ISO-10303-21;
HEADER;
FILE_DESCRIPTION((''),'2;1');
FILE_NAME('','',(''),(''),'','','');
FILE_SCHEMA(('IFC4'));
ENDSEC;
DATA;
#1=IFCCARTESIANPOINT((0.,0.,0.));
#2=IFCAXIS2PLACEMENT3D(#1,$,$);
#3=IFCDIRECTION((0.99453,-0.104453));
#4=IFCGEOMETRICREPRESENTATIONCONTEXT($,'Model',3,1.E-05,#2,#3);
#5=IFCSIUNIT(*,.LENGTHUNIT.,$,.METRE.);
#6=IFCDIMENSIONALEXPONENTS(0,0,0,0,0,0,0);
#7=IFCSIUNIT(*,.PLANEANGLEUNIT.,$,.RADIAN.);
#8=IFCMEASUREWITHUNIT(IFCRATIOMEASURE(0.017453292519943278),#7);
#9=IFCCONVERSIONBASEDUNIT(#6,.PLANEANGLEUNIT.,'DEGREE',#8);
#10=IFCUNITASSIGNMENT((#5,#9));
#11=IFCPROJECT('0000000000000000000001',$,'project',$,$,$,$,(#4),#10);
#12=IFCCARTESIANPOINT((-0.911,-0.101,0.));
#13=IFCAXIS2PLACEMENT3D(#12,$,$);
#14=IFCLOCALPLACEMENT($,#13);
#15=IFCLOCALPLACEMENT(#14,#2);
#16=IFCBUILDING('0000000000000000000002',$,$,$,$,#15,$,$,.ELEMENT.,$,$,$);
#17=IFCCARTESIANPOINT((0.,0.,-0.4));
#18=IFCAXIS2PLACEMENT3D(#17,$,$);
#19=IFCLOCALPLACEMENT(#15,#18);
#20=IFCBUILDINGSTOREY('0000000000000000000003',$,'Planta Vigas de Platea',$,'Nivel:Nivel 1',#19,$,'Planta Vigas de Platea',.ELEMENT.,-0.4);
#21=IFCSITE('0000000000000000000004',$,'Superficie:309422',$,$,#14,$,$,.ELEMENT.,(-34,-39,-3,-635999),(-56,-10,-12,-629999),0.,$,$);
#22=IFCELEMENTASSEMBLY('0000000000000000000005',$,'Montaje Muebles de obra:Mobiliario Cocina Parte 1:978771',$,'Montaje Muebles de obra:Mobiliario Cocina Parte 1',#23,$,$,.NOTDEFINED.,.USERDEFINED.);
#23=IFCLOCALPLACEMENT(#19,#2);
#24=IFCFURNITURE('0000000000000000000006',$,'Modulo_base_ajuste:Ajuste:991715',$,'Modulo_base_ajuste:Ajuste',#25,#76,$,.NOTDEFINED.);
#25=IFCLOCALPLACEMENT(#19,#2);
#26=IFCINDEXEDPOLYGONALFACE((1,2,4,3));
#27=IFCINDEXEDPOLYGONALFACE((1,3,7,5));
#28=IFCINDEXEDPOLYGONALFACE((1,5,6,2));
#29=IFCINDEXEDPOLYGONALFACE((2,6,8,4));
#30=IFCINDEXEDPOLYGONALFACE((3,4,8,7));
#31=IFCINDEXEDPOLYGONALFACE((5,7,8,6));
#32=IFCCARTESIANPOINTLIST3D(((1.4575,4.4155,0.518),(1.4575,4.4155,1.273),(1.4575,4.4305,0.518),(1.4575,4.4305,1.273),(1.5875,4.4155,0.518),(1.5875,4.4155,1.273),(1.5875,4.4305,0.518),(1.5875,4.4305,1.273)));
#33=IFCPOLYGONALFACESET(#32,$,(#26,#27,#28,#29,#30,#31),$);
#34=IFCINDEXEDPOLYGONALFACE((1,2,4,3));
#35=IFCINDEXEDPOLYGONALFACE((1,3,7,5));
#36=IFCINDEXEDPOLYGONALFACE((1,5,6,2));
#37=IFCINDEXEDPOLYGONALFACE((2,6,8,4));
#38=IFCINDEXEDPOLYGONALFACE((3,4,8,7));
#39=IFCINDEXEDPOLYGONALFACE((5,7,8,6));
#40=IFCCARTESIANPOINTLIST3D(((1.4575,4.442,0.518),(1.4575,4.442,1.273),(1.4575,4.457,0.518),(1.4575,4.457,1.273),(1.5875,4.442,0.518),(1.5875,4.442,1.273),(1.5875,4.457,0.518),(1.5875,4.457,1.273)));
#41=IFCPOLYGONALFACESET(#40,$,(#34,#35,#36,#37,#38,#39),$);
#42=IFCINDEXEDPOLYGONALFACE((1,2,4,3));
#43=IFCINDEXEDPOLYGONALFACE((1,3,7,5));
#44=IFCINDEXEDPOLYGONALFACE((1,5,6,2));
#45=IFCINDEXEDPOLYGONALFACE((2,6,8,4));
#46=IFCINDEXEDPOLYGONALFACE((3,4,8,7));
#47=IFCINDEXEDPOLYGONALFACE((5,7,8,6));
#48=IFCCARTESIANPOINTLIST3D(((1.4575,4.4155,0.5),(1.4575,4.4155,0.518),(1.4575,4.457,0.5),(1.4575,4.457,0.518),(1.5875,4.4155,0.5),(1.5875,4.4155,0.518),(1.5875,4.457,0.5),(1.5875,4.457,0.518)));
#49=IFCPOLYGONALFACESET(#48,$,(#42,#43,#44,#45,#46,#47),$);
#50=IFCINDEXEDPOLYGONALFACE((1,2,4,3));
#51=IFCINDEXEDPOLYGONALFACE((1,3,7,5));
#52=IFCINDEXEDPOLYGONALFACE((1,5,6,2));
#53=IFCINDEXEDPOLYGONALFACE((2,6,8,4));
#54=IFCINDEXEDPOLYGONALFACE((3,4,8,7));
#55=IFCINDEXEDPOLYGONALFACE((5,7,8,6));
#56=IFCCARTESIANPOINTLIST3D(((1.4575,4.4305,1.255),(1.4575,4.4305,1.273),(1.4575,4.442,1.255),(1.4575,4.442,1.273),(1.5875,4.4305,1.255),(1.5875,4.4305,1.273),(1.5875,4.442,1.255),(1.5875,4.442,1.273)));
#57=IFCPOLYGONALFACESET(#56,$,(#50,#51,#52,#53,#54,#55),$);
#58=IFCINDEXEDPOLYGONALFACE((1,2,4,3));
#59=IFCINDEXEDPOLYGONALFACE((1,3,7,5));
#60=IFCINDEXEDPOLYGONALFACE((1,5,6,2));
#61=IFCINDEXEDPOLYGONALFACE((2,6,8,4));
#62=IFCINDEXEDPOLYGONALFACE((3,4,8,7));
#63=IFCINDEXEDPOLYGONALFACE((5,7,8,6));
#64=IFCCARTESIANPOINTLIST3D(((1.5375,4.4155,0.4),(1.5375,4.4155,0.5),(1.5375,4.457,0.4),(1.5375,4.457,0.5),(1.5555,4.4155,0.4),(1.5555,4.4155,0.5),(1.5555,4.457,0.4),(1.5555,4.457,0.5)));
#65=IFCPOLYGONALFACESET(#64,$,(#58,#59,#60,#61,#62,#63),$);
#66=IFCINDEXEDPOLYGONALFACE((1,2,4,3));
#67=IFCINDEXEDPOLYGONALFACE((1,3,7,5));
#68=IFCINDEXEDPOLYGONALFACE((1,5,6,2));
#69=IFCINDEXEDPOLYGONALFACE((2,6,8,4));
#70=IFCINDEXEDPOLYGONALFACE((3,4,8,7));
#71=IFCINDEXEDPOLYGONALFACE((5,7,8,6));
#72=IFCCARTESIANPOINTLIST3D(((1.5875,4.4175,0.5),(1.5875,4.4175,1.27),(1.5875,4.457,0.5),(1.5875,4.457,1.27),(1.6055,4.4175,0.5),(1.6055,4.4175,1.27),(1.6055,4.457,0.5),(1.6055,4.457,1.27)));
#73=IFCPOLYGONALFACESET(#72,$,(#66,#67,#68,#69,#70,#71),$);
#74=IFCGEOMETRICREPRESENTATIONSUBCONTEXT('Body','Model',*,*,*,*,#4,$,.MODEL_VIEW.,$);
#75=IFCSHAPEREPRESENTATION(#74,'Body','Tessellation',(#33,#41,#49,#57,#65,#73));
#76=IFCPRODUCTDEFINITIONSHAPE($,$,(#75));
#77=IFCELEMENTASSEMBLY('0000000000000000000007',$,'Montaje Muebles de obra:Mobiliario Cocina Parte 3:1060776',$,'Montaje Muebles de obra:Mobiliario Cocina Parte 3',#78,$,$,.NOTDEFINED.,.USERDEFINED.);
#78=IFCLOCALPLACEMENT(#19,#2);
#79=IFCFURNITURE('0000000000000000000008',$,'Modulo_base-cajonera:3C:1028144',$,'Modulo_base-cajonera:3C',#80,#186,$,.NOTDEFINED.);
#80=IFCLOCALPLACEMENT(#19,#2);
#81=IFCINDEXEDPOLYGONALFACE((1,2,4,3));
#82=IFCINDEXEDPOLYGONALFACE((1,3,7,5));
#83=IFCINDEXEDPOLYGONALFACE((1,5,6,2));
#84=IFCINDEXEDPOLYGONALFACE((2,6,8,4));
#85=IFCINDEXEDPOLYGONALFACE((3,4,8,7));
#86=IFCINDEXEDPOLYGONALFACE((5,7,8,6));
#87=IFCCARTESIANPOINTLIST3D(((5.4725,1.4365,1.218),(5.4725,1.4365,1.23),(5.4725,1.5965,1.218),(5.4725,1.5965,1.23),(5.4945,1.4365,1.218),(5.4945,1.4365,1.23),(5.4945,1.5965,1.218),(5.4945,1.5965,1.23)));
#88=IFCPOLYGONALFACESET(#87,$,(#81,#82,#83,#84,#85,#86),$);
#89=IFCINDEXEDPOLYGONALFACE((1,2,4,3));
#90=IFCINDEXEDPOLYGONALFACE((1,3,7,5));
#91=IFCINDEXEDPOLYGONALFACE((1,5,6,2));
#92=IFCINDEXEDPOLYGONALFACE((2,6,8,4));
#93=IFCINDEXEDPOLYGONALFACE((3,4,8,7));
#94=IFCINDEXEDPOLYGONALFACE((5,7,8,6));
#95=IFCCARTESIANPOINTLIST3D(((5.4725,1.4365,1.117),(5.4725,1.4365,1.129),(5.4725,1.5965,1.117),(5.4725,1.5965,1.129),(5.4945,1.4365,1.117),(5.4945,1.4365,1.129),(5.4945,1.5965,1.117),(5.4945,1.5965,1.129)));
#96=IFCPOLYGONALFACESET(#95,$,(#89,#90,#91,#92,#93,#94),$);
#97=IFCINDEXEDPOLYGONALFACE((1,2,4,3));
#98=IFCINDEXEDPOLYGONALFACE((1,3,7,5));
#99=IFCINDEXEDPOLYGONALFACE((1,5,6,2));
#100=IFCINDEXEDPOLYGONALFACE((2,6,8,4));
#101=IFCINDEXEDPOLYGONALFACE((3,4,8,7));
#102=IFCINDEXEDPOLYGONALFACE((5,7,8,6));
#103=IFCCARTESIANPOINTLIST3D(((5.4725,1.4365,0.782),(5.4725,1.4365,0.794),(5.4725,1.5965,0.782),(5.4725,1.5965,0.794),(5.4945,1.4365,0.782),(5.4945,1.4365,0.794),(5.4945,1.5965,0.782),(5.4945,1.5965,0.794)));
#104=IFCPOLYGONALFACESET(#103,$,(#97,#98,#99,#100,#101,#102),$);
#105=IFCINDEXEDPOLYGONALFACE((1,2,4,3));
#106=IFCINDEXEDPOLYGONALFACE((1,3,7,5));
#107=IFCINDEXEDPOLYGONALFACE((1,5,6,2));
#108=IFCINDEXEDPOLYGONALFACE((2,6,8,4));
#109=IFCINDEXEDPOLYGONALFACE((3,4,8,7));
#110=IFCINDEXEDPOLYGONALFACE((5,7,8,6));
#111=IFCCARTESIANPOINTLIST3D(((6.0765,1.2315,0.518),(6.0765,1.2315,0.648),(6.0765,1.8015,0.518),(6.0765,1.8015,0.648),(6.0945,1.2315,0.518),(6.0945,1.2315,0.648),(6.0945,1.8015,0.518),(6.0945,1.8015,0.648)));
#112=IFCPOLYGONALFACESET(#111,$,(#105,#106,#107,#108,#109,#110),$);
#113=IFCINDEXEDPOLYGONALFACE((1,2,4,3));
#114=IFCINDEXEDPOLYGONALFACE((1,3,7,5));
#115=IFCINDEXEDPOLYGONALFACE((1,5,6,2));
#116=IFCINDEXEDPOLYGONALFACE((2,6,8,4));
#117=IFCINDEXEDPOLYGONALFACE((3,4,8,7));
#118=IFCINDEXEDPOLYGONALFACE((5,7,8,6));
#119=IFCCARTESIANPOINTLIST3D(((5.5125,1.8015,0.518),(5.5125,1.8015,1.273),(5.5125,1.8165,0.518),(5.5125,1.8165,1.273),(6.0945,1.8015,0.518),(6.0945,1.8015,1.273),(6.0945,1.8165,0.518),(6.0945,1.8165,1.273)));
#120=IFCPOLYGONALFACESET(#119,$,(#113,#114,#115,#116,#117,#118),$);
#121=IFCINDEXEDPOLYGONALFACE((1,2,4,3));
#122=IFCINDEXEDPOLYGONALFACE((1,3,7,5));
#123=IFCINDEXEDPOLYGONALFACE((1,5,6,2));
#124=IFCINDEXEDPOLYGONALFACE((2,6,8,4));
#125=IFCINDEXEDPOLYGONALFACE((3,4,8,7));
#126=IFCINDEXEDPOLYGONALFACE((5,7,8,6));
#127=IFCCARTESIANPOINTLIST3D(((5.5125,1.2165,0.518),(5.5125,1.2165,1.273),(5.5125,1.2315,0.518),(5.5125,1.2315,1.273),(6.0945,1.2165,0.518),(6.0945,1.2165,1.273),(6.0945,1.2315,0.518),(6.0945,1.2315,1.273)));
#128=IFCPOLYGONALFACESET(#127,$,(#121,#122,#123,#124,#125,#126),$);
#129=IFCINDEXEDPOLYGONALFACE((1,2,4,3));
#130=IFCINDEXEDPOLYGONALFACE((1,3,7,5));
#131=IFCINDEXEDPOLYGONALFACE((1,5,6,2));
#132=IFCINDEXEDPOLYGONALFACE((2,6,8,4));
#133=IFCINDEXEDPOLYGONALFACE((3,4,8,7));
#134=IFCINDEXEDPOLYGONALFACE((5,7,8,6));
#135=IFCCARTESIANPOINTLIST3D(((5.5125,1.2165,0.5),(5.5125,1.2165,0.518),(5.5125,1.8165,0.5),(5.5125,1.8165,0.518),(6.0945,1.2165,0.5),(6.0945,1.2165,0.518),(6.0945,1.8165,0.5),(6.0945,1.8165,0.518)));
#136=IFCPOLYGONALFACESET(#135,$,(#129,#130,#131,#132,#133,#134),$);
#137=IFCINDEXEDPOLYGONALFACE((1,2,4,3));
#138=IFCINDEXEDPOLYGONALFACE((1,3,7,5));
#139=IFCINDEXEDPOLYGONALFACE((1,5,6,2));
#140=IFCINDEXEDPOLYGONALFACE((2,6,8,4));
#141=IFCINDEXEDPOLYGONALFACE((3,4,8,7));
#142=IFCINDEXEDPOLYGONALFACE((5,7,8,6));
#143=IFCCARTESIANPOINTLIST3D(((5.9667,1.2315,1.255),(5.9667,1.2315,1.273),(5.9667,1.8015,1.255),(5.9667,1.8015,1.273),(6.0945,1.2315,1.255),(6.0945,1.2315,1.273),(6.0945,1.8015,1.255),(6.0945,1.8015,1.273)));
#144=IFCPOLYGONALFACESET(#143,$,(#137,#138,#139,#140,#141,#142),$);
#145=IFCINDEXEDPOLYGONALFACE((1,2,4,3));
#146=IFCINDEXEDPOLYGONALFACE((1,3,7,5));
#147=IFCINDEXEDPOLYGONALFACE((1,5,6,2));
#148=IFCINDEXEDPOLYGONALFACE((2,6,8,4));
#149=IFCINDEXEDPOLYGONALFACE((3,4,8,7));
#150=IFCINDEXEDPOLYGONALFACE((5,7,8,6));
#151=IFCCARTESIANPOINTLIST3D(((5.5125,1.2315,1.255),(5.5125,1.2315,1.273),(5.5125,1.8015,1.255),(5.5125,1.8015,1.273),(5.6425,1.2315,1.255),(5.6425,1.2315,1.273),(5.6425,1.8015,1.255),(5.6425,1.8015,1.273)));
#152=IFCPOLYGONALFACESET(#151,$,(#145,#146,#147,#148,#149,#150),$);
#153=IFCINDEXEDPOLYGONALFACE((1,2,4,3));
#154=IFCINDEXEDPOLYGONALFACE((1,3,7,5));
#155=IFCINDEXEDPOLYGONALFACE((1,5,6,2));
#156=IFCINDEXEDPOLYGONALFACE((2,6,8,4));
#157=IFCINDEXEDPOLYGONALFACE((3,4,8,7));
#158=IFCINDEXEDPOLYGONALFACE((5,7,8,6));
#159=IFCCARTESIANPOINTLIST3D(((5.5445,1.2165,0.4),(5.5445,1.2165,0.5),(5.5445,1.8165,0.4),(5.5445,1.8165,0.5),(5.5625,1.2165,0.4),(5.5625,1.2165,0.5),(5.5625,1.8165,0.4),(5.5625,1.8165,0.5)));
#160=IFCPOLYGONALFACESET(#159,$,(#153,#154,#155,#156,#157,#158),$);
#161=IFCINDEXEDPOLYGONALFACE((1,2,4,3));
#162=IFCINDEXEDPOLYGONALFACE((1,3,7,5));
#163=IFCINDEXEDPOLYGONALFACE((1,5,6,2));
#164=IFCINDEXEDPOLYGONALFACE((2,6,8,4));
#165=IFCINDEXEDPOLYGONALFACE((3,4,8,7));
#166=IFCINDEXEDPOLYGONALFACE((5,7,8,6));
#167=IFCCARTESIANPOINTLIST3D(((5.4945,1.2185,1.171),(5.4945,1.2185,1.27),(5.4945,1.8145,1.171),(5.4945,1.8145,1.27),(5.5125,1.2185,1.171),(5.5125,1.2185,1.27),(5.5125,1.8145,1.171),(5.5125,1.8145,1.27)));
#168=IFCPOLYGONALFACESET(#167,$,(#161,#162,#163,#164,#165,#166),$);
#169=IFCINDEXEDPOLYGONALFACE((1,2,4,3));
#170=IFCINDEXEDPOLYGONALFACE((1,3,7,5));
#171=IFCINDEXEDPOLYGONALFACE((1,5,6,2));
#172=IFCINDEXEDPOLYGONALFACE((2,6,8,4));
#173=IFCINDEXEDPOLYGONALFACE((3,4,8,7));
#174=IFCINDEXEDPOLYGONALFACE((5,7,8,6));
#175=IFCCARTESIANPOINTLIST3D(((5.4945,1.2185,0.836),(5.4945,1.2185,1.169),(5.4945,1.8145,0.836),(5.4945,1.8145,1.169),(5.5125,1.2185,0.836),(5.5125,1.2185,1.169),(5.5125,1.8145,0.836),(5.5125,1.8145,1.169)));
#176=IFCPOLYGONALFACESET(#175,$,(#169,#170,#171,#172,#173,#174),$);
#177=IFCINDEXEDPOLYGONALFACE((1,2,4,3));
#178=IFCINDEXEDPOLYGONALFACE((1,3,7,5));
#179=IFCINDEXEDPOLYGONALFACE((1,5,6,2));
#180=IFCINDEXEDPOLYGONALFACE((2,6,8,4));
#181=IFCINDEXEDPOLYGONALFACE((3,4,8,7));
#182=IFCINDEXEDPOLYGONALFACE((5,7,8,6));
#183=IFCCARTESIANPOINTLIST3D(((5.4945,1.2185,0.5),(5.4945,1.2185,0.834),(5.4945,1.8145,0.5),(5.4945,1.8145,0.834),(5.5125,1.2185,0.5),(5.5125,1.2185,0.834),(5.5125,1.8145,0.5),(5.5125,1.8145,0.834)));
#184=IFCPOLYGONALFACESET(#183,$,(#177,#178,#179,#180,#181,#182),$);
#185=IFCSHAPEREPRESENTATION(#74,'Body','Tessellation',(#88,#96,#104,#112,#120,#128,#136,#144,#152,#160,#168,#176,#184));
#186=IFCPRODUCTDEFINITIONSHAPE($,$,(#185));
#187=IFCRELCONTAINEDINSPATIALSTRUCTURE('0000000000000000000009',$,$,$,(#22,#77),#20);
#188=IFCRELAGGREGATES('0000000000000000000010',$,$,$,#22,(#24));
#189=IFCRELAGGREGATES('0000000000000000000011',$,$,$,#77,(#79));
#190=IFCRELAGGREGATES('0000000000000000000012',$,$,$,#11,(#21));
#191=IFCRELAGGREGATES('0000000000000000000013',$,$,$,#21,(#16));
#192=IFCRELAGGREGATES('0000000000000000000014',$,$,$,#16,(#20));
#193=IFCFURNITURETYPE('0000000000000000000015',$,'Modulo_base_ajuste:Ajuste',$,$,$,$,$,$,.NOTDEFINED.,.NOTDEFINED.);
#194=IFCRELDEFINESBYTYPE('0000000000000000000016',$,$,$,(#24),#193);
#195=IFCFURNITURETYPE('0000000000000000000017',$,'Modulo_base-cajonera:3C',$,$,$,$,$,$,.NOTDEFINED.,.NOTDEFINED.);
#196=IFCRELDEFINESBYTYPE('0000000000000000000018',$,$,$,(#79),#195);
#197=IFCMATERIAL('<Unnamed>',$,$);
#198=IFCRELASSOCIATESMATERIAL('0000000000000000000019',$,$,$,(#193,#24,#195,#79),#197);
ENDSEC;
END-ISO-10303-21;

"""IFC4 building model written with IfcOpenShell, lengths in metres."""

from ifc_helpers import new_model, entity, si_unit, converted_unit, direction, frame, frame_2d, origin, origin_2d_with_axis, place, context, subcontext, project, spatial, rectangle, extrude, source, transform, mapped, material, type_object, type_shapes, element, aggregate, save


model = new_model("IFC4")

# Units and contexts
model_context = context("Model", 3, precision=1e-05, world=origin(), true_north=direction((0.99453, -0.104453)))
body_context = subcontext(model_context, "Body", "Model", "MODEL_VIEW")
ifc_project = project(units=[si_unit("LENGTHUNIT", "METRE"), converted_unit("PLANEANGLEUNIT", "DEGREE", entity("IfcRatioMeasure", 0.017453292519943278), si_unit("PLANEANGLEUNIT", "RADIAN"), dimensions=[0, 0, 0, 0, 0, 0, 0])], contexts=[model_context])

# Site, building, storey
site_placement = place(None, frame((-0.911, -0.101, 0.0)))
site = spatial("IfcSite", under=ifc_project, at=site_placement, Name="Superficie:309422", CompositionType="ELEMENT", RefLatitude=(-34, -39, -3, -635999), RefLongitude=(-56, -10, -12, -629999), RefElevation=0.0)
building_placement = place(site_placement, origin())
building = spatial("IfcBuilding", under=site, at=building_placement, CompositionType="ELEMENT")
storey_placement = place(building_placement, frame((0.0, 0.0, -0.4)))
storey = spatial("IfcBuildingStorey", under=building, at=storey_placement, Name="Planta Vigas de Platea", ObjectType="Nivel:Nivel 1", LongName="Planta Vigas de Platea", CompositionType="ELEMENT", Elevation=-0.4)

# Element assemblies, furniture
assembly_1_placement = place(storey_placement, origin())
assembly_1 = element("IfcElementAssembly", 1, at=assembly_1_placement, inside=storey, Name="Montaje Muebles de obra:Mobiliario Cocina Parte 1:978771", ObjectType="Montaje Muebles de obra:Mobiliario Cocina Parte 1", AssemblyPlace="NOTDEFINED", PredefinedType="USERDEFINED")
ifc_material_1 = material(Name="<Unnamed>")
furniture_type_1 = type_object("IfcFurnitureType", Name="Modulo_base_ajuste:Ajuste", AssemblyPlace="NOTDEFINED", PredefinedType="NOTDEFINED", material=ifc_material_1)
shared_shape_1 = source(origin(), body_context, "Body", "SweptSolid", [
    extrude(rectangle(XDim=0.015, YDim=0.13, at=frame_2d((0.0, 0.0), x_axis=(1.0, 0.0))), frame((0.065, 0.0075, 0.118), z_axis=(0.0, 0.0, 1.0), x_axis=(0.0, -1.0, 0.0)), (0.0, 0.0, 1.0), 0.755),
    extrude(rectangle(XDim=0.015, YDim=0.13, at=frame_2d((0.0, 0.0), x_axis=(1.0, 0.0))), frame((0.065, 0.034, 0.118), z_axis=(0.0, 0.0, 1.0), x_axis=(0.0, 1.0, 0.0)), (0.0, 0.0, 1.0), 0.755),
    extrude(rectangle(XDim=0.0415, YDim=0.13, at=frame_2d((0.0, 0.0), x_axis=(1.0, 0.0))), frame((0.065, 0.0208, 0.1), z_axis=(0.0, 0.0, 1.0), x_axis=(0.0, -1.0, 0.0)), (0.0, 0.0, 1.0), 0.018),
    extrude(rectangle(XDim=0.0115, YDim=0.13, at=frame_2d((0.0, 0.0), x_axis=(1.0, 0.0))), frame((0.065, 0.0208, 0.855), z_axis=(0.0, 0.0, 1.0), x_axis=(0.0, -1.0, 0.0)), (0.0, 0.0, 1.0), 0.018),
    extrude(rectangle(XDim=0.018, YDim=0.0415, at=origin_2d_with_axis()), frame((0.089, 0.0208, 0.0)), (0.0, 0.0, 1.0), 0.1),
    extrude(rectangle(XDim=0.018, YDim=0.0395, at=frame_2d((0.0, 0.0), x_axis=(1.0, 0.0))), frame((0.139, 0.0218, 0.1), z_axis=(0.0, 0.0, 1.0), x_axis=(-1.0, 0.0, 0.0)), (0.0, 0.0, 1.0), 0.77),
])
type_shapes(furniture_type_1, [shared_shape_1])
furniture_1_placement = place(assembly_1_placement, frame((1.4575, 4.4155, 0.4)))
furniture_1 = element("IfcFurniture", 2, at=furniture_1_placement, type_object=furniture_type_1, material=ifc_material_1, Name="Modulo_base_ajuste:Ajuste:991715", ObjectType="Modulo_base_ajuste:Ajuste", PredefinedType="NOTDEFINED", context=body_context, shape_type="MappedRepresentation", body=[
    mapped(shared_shape_1, transform((0.0, 0.0, 0.0), scale=1.0)),
])
aggregate(assembly_1, [furniture_1])
assembly_2_placement = place(storey_placement, origin())
assembly_2 = element("IfcElementAssembly", 3, at=assembly_2_placement, inside=storey, Name="Montaje Muebles de obra:Mobiliario Cocina Parte 3:1060776", ObjectType="Montaje Muebles de obra:Mobiliario Cocina Parte 3", AssemblyPlace="NOTDEFINED", PredefinedType="USERDEFINED")
furniture_type_2 = type_object("IfcFurnitureType", Name="Modulo_base-cajonera:3C", AssemblyPlace="NOTDEFINED", PredefinedType="NOTDEFINED", material=ifc_material_1)
shared_shape_2 = source(origin(), body_context, "Body", "SweptSolid", [
    extrude(rectangle(XDim=0.022, YDim=0.16, at=frame_2d((0.0, 0.0), x_axis=(1.0, 0.0))), frame((0.011, 0.3, 0.818)), (0.0, 0.0, 1.0), 0.012),
    extrude(rectangle(XDim=0.022, YDim=0.16, at=frame_2d((0.0, 0.0), x_axis=(1.0, 0.0))), frame((0.011, 0.3, 0.717)), (0.0, 0.0, 1.0), 0.012),
    extrude(rectangle(XDim=0.022, YDim=0.16, at=frame_2d((0.0, 0.0), x_axis=(1.0, 0.0))), frame((0.011, 0.3, 0.382)), (0.0, 0.0, 1.0), 0.012),
    extrude(rectangle(XDim=0.57, YDim=0.018, at=frame_2d((0.0, 0.0), x_axis=(1.0, 0.0))), frame((0.613, 0.3, 0.118), z_axis=(0.0, 0.0, 1.0), x_axis=(0.0, 1.0, 0.0)), (0.0, 0.0, 1.0), 0.13),
    extrude(rectangle(XDim=0.015, YDim=0.582, at=frame_2d((0.0, 0.0), x_axis=(1.0, 0.0))), frame((0.331, 0.5925, 0.118), z_axis=(0.0, 0.0, 1.0), x_axis=(0.0, 1.0, 0.0)), (0.0, 0.0, 1.0), 0.755),
    extrude(rectangle(XDim=0.015, YDim=0.582, at=origin_2d_with_axis()), frame((0.331, 0.0075, 0.118), z_axis=(0.0, 0.0, 1.0), x_axis=(0.0, -1.0, 0.0)), (0.0, 0.0, 1.0), 0.755),
    extrude(rectangle(XDim=0.6, YDim=0.582, at=frame_2d((0.0, 0.0), x_axis=(1.0, 0.0))), frame((0.331, 0.3, 0.1), z_axis=(0.0, 0.0, 1.0), x_axis=(0.0, 1.0, 0.0)), (0.0, 0.0, 1.0), 0.018),
    extrude(rectangle(XDim=0.57, YDim=0.1278, at=frame_2d((0.0, 0.0), x_axis=(1.0, 0.0))), frame((0.5581, 0.3, 0.855), z_axis=(0.0, 0.0, 1.0), x_axis=(0.0, 1.0, 0.0)), (0.0, 0.0, 1.0), 0.018),
    extrude(rectangle(XDim=0.57, YDim=0.13, at=frame_2d((0.0, 0.0), x_axis=(1.0, 0.0))), frame((0.105, 0.3, 0.855), z_axis=(0.0, 0.0, 1.0), x_axis=(0.0, 1.0, 0.0)), (0.0, 0.0, 1.0), 0.018),
    extrude(rectangle(XDim=0.018, YDim=0.6, at=frame_2d((0.0, 0.0), x_axis=(1.0, 0.0))), frame((0.081, 0.3, 0.0), z_axis=(0.0, 0.0, 1.0), x_axis=(-1.0, 0.0, 0.0)), (0.0, 0.0, 1.0), 0.1),
    extrude(rectangle(XDim=0.018, YDim=0.596, at=frame_2d((0.0, 0.0), x_axis=(1.0, 0.0))), frame((0.031, 0.3, 0.771)), (0.0, 0.0, 1.0), 0.099),
    extrude(rectangle(XDim=0.018, YDim=0.596, at=frame_2d((0.0, 0.0), x_axis=(1.0, 0.0))), frame((0.031, 0.3, 0.436)), (0.0, 0.0, 1.0), 0.333),
    extrude(rectangle(XDim=0.018, YDim=0.596, at=frame_2d((0.0, 0.0), x_axis=(1.0, 0.0))), frame((0.031, 0.3, 0.1)), (0.0, 0.0, 1.0), 0.334),
])
type_shapes(furniture_type_2, [shared_shape_2])
furniture_2_placement = place(assembly_2_placement, frame((5.4725, 1.2165, 0.4)))
furniture_2 = element("IfcFurniture", 4, at=furniture_2_placement, type_object=furniture_type_2, material=ifc_material_1, Name="Modulo_base-cajonera:3C:1028144", ObjectType="Modulo_base-cajonera:3C", PredefinedType="NOTDEFINED", context=body_context, shape_type="MappedRepresentation", body=[
    mapped(shared_shape_2, transform((0.0, 0.0, 0.0), scale=1.0)),
])

aggregate(assembly_2, [furniture_2])

save(model, "model.ifc")
